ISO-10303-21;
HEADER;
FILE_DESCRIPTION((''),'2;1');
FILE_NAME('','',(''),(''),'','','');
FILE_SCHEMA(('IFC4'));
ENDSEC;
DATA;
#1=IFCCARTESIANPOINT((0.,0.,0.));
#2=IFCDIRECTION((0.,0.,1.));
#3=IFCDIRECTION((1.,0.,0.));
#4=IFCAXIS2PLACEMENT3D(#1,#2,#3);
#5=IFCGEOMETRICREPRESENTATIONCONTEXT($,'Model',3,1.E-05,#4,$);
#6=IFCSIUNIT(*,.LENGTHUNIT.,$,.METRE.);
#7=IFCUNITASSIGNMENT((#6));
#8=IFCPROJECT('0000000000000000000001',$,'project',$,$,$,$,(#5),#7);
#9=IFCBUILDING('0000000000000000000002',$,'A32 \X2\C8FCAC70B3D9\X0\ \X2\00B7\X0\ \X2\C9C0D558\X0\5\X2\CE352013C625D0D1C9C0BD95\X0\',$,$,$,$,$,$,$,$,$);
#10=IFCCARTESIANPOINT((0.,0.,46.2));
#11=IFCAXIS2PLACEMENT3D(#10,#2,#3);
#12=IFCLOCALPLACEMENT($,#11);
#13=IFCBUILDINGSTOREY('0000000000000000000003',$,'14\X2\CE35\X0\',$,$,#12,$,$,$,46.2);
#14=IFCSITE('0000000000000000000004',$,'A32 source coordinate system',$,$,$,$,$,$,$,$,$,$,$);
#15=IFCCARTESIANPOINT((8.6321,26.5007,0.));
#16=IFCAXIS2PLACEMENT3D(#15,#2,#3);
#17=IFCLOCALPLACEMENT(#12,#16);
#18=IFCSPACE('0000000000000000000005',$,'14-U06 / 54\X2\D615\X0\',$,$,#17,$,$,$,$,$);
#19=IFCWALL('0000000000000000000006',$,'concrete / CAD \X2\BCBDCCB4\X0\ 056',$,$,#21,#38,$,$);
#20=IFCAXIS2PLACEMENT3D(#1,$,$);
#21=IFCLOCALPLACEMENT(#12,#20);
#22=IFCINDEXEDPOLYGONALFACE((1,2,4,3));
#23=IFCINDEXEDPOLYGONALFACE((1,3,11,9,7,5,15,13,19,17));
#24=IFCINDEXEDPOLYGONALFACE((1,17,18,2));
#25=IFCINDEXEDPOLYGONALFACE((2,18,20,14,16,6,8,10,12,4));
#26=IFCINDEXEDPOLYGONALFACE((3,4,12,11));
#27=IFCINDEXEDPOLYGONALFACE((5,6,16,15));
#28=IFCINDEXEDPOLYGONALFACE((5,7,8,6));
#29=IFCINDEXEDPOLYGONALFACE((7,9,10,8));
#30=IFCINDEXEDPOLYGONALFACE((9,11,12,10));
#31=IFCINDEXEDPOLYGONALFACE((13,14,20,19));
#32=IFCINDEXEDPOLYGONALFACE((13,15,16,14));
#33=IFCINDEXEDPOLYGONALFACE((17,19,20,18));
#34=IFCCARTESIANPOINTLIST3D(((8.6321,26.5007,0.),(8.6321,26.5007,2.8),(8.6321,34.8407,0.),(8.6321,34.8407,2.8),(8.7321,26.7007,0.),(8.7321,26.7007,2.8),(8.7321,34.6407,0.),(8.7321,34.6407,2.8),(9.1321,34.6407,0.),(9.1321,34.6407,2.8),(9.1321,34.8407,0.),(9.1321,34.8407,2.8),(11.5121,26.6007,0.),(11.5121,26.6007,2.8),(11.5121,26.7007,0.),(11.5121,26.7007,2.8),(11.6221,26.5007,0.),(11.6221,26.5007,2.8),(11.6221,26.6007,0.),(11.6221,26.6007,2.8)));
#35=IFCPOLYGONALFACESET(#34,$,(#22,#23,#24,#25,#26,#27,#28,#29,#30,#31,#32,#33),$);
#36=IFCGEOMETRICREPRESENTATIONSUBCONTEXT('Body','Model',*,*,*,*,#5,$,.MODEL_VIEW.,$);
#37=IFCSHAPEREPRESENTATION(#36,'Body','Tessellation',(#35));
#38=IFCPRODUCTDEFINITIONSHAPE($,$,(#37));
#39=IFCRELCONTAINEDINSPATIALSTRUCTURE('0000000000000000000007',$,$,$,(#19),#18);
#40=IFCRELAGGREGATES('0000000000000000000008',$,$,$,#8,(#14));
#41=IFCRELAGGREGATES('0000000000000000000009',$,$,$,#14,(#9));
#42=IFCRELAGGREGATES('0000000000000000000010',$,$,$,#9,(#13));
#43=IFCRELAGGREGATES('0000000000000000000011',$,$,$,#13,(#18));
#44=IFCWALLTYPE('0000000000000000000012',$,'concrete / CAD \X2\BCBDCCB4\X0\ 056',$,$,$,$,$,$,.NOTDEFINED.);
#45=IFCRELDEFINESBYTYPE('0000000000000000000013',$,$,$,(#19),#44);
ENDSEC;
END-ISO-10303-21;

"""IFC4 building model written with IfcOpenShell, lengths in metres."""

from ifc_helpers import new_model, si_unit, frame, origin, origin_with_axes, place, context, subcontext, project, spatial, polyline, outline, extrude, source, transform, mapped, type_object, type_shapes, element, save


model = new_model("IFC4")

# Units and contexts
model_context = context("Model", 3, precision=1e-05, world=origin_with_axes())
body_context = subcontext(model_context, "Body", "Model", "MODEL_VIEW")
ifc_project = project(units=[si_unit("LENGTHUNIT", "METRE")], contexts=[model_context])

# Site, building, storey, space
site = spatial("IfcSite", under=ifc_project, Name="A32 source coordinate system")
building = spatial("IfcBuilding", under=site, Name="A32 주거동 · 지하5층–옥탑지붕")
storey_placement = place(None, frame((0.0, 0.0, 46.2), z_axis=(0.0, 0.0, 1.0), x_axis=(1.0, 0.0, 0.0)))
storey = spatial("IfcBuildingStorey", under=building, at=storey_placement, Name="14층", Elevation=46.2)
space_placement = place(storey_placement, frame((8.6321, 26.5007, 0.0), z_axis=(0.0, 0.0, 1.0), x_axis=(1.0, 0.0, 0.0)))
space = spatial("IfcSpace", under=storey, at=space_placement, Name="14-U06 / 54형")

# Wall
wall_type_1 = type_object("IfcWallType", Name="concrete / CAD 벽체 056", PredefinedType="NOTDEFINED")
shared_shape_1 = source(origin(), body_context, "Body", "SweptSolid", [
    extrude(outline(polyline([(0.1, 8.14), (0.1, 0.2), (2.88, 0.2), (2.88, 0.1), (2.99, 0.1), (2.99, 0.0), (0.0, 0.0), (0.0, 8.34), (-0.35, 8.34), (-0.35, 8.34), (0.5, 8.34), (0.5, 8.14), (0.1, 8.14)])), origin(), (0.0, 0.0, 1.0), 2.8),
])
type_shapes(wall_type_1, [shared_shape_1])
wall_1_placement = place(space_placement, origin_with_axes())
element("IfcWall", 1, at=wall_1_placement, inside=space, type_object=wall_type_1, Name="concrete / CAD 벽체 056", context=body_context, shape_type="MappedRepresentation", body=[
    mapped(shared_shape_1, transform((0.0, 0.0, 0.0), scale=1.0)),
])

save(model, "model.ifc")
